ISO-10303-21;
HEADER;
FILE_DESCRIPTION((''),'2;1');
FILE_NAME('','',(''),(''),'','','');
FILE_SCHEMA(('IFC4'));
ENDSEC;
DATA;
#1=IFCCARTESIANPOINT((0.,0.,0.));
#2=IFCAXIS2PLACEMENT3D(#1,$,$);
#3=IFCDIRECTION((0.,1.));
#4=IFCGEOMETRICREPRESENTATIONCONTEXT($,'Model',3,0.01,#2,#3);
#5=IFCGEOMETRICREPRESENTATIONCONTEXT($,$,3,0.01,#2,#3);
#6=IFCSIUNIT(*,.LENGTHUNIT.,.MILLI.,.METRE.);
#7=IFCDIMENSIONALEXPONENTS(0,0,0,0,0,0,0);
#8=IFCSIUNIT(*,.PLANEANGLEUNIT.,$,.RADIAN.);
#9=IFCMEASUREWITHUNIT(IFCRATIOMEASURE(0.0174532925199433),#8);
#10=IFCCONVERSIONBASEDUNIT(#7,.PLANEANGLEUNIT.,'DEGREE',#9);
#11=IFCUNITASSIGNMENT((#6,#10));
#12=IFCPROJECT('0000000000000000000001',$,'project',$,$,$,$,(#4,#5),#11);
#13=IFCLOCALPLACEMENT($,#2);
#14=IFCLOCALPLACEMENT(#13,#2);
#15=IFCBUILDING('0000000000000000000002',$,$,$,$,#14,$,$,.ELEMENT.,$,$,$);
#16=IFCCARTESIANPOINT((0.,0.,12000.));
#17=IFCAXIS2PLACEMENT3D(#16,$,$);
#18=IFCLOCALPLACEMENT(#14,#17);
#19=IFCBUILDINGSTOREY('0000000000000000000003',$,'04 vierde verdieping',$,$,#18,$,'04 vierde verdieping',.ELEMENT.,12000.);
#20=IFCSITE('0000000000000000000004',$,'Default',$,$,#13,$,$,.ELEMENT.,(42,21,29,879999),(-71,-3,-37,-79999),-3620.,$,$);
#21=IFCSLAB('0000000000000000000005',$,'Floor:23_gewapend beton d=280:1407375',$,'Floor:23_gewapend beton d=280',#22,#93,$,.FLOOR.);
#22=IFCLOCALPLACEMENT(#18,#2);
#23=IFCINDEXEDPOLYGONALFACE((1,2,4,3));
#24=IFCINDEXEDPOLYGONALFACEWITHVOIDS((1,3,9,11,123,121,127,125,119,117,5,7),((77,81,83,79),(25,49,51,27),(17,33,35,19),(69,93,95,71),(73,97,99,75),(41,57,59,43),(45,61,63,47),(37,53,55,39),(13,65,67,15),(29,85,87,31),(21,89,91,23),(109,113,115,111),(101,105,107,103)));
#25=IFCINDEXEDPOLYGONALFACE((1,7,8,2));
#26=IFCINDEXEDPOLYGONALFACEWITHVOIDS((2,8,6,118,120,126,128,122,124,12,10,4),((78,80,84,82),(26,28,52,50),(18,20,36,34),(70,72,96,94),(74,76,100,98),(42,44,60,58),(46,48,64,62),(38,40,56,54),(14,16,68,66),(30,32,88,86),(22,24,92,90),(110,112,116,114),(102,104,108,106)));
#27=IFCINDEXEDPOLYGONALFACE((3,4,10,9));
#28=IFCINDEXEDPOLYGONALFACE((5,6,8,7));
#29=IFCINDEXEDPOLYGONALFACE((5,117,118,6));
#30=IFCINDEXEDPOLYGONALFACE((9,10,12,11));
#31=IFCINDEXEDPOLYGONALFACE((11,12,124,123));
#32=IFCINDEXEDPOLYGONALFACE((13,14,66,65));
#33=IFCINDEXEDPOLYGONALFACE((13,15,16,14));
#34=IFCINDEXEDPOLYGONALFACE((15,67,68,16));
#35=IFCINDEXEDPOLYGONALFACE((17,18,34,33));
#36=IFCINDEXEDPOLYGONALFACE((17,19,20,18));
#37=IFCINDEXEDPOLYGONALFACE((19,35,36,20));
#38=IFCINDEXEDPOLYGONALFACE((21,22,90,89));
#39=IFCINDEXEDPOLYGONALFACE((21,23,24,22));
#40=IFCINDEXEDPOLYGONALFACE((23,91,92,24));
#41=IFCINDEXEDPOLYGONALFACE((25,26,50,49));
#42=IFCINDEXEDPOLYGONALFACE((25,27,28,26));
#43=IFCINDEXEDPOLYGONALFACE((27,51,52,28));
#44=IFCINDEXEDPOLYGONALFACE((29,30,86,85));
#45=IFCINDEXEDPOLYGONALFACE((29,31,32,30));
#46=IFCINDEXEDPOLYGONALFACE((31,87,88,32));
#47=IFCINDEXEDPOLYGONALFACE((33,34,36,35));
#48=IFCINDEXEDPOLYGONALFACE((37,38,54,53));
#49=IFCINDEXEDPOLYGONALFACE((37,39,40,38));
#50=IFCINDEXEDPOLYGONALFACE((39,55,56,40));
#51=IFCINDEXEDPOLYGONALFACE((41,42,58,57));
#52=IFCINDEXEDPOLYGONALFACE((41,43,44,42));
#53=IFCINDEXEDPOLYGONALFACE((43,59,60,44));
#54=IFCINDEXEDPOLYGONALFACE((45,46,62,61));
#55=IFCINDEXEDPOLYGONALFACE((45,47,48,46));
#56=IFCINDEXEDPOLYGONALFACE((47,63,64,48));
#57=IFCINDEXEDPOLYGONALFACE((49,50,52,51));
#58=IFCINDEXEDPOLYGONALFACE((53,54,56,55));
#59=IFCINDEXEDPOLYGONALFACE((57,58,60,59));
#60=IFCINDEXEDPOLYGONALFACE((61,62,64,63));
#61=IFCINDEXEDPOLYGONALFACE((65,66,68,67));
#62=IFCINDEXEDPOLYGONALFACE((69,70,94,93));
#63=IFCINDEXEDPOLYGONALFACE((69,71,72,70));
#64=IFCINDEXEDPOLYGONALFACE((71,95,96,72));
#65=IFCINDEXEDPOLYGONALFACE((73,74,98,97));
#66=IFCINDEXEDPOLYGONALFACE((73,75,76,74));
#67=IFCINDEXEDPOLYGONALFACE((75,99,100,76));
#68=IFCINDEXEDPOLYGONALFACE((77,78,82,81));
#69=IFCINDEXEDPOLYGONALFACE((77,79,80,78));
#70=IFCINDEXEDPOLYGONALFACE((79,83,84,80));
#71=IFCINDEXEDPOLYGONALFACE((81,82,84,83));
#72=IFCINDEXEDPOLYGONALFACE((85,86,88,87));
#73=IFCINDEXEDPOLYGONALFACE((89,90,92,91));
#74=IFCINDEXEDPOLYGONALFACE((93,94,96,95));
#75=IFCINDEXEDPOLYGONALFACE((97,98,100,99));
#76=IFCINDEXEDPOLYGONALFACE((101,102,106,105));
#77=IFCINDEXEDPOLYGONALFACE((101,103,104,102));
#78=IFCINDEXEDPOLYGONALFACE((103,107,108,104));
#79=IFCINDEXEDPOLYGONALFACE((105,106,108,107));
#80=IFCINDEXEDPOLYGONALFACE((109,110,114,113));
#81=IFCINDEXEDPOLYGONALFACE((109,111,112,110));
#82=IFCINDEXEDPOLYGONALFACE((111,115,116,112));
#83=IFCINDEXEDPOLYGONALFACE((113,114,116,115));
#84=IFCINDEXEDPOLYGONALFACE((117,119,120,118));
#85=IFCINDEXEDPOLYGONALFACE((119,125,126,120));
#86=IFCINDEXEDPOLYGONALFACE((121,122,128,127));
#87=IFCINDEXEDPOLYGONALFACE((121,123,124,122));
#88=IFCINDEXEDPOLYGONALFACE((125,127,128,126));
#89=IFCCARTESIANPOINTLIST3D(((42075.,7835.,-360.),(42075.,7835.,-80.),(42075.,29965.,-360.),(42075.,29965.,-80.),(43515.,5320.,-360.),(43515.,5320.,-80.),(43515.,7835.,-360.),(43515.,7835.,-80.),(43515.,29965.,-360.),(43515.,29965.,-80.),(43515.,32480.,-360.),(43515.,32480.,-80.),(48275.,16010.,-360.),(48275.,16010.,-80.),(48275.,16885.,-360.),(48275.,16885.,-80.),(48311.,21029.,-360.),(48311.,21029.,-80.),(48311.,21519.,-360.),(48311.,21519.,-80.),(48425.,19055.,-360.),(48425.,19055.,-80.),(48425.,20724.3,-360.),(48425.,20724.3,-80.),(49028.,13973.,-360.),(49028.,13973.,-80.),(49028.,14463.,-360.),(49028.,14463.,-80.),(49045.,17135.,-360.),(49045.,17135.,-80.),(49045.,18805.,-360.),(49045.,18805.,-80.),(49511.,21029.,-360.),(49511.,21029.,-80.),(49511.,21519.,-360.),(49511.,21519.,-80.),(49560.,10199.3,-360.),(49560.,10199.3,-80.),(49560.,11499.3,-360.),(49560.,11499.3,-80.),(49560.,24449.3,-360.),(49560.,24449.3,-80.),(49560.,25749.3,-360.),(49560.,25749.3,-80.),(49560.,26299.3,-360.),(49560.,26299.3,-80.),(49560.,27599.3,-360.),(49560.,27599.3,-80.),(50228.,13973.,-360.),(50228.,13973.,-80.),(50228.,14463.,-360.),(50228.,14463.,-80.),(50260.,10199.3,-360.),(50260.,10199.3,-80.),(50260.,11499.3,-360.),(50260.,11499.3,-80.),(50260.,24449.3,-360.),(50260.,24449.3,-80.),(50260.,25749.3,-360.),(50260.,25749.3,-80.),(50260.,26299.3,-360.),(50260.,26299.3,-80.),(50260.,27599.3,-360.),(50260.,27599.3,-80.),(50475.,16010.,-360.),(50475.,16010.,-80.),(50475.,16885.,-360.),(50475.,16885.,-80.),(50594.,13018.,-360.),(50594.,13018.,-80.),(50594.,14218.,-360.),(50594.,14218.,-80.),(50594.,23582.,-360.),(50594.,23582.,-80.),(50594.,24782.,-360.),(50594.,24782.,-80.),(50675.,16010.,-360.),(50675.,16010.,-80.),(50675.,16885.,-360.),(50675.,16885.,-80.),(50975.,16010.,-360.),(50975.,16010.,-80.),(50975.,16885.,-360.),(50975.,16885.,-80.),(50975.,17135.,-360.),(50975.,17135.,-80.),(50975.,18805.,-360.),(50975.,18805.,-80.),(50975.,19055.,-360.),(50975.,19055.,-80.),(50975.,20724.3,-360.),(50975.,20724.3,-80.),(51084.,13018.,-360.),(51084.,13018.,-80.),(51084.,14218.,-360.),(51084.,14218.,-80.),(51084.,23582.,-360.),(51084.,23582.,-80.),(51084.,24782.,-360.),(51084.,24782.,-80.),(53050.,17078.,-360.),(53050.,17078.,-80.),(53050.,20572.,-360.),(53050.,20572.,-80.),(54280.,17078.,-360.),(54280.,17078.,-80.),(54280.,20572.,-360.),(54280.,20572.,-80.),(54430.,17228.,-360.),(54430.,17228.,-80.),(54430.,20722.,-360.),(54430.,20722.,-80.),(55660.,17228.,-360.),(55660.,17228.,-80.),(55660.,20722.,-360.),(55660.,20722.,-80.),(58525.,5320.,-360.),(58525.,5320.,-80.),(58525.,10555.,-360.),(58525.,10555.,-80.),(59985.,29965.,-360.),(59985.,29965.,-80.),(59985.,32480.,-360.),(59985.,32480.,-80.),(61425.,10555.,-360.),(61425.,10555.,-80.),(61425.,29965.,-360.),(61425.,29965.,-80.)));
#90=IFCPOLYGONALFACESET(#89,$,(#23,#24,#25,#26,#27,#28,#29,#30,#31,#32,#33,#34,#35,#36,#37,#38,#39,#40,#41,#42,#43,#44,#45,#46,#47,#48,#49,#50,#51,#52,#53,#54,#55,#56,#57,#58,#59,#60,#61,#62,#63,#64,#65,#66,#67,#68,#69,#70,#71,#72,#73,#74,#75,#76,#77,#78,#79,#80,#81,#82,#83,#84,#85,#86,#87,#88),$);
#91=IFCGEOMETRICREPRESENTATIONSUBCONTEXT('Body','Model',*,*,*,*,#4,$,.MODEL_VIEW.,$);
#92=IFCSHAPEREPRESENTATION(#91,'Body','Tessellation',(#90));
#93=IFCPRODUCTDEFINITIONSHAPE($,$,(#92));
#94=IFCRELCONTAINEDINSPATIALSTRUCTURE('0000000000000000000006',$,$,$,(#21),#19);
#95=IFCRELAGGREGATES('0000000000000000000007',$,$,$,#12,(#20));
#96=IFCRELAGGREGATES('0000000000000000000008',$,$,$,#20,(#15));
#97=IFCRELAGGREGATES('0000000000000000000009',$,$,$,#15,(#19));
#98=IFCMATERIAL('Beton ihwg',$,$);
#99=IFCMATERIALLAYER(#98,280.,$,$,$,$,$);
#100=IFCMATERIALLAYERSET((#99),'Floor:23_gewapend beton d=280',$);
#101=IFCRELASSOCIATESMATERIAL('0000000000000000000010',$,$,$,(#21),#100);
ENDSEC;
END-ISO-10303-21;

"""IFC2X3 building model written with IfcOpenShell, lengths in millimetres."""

from ifc_helpers import new_model, entity, si_unit, converted_unit, direction, frame, frame_2d, origin, place, context, subcontext, project, spatial, polyline, rectangle, outline, extrude, material, layer, layer_set, layer_usage, element, save


model = new_model("IFC2X3")

# Units and contexts
model_context = context("Model", 3, precision=0.01, world=origin(), true_north=direction((0.0, 1.0)))
context_of_model = context(None, 3, precision=0.01, world=origin(), true_north=direction((0.0, 1.0)))
body_context = subcontext(model_context, "Body", "Model", "MODEL_VIEW")
ifc_project = project(units=[si_unit("LENGTHUNIT", "METRE", prefix="MILLI"), converted_unit("PLANEANGLEUNIT", "DEGREE", entity("IfcRatioMeasure", 0.0174532925199433), si_unit("PLANEANGLEUNIT", "RADIAN"), dimensions=[0, 0, 0, 0, 0, 0, 0])], contexts=[model_context, context_of_model])

# Site, building, storey
site_placement = place(None, origin())
site = spatial("IfcSite", under=ifc_project, at=site_placement, Name="Default", CompositionType="ELEMENT", RefLatitude=(42, 21, 29, 879999), RefLongitude=(-71, -3, -37, -79999), RefElevation=-3620.0)
building_placement = place(site_placement, origin())
building = spatial("IfcBuilding", under=site, at=building_placement, CompositionType="ELEMENT")
storey_placement = place(building_placement, frame((0.0, 0.0, 12000.0)))
storey = spatial("IfcBuildingStorey", under=building, at=storey_placement, Name="04 vierde verdieping", LongName="04 vierde verdieping", CompositionType="ELEMENT", Elevation=12000.0)

# Slab, openings
ifc_material_1 = material(Name="Beton ihwg")
ifc_layer_1 = layer(ifc_material_1, 280.0)
ifc_layer_set_1 = layer_set([ifc_layer_1], Name="Floor:23_gewapend beton d=280")
ifc_layer_usage_1 = layer_usage(ifc_layer_set_1, "AXIS3", "POSITIVE", 0.0)
slab_1_placement = place(storey_placement, frame((42075.0, 5320.0, -360.0)))
slab_1 = element("IfcSlab", 1, at=slab_1_placement, inside=storey, material=ifc_layer_usage_1, Name="Floor:23_gewapend beton d=280:1407375", ObjectType="Floor:23_gewapend beton d=280", PredefinedType="FLOOR", context=body_context, shape_type="SweptSolid", body=[
    extrude(outline(polyline([(8235.0, 13580.0), (-8235.0, 13580.0), (-8235.0, 11065.0), (-9675.0, 11065.0), (-9675.0, -8345.0), (-6775.0, -8345.0), (-6775.0, -13580.0), (8235.0, -13580.0), (8235.0, -11065.0), (9675.0, -11065.0), (9675.0, 11065.0), (8235.0, 11065.0), (8235.0, 13580.0)])), frame((9675.0, 13580.0, 280.0), z_axis=(0.0, 0.0, -1.0), x_axis=(-1.0, 0.0, 0.0)), (0.0, 0.0, 1.0), 280.0),
])
opening_1_placement = place(storey_placement, frame((42075.0, 5320.0, -360.0)))
element("IfcOpeningElement", 2, at=opening_1_placement, cuts=slab_1, ObjectType="Opening", context=body_context, shape_type="SweptSolid", body=[
    extrude(rectangle(XDim=1669.3, YDim=2550.0, at=frame_2d((2050.0, 989.6), x_axis=(0.0, 1.0))), frame((9675.0, 13580.0, 280.0), z_axis=(0.0, 0.0, -1.0), x_axis=(-1.0, 0.0, 0.0)), (0.0, 0.0, 1.0), 280.0),
])
opening_2_placement = place(storey_placement, frame((42075.0, 5320.0, -360.0)))
element("IfcOpeningElement", 3, at=opening_2_placement, cuts=slab_1, ObjectType="Opening", context=body_context, shape_type="SweptSolid", body=[
    extrude(rectangle(XDim=1670.0, YDim=1930.0, at=frame_2d((1740.0, -930.0), x_axis=(0.0, 1.0))), frame((9675.0, 13580.0, 280.0), z_axis=(0.0, 0.0, -1.0), x_axis=(-1.0, 0.0, 0.0)), (0.0, 0.0, 1.0), 280.0),
])
opening_3_placement = place(storey_placement, frame((42075.0, 5320.0, -360.0)))
element("IfcOpeningElement", 4, at=opening_3_placement, cuts=slab_1, ObjectType="Opening", context=body_context, shape_type="SweptSolid", body=[
    extrude(rectangle(XDim=1300.0, YDim=700.0, at=frame_2d((1840.0, 8049.3), x_axis=(0.0, 1.0))), frame((9675.0, 13580.0, 280.0), z_axis=(0.0, 0.0, -1.0), x_axis=(-1.0, 0.0, 0.0)), (0.0, 0.0, 1.0), 280.0),
])
opening_4_placement = place(storey_placement, frame((42075.0, 5320.0, -360.0)))
element("IfcOpeningElement", 5, at=opening_4_placement, cuts=slab_1, ObjectType="Opening", context=body_context, shape_type="SweptSolid", body=[
    extrude(rectangle(XDim=1300.0, YDim=700.0, at=frame_2d((1840.0, 6199.3), x_axis=(0.0, 1.0))), frame((9675.0, 13580.0, 280.0), z_axis=(0.0, 0.0, -1.0), x_axis=(-1.0, 0.0, 0.0)), (0.0, 0.0, 1.0), 280.0),
])
opening_5_placement = place(storey_placement, frame((42075.0, 5320.0, -360.0)))
element("IfcOpeningElement", 6, at=opening_5_placement, cuts=slab_1, ObjectType="Opening", context=body_context, shape_type="SweptSolid", body=[
    extrude(rectangle(XDim=1300.0, YDim=700.0, at=frame_2d((1840.0, -8050.7), x_axis=(0.0, 1.0))), frame((9675.0, 13580.0, 280.0), z_axis=(0.0, 0.0, -1.0), x_axis=(-1.0, 0.0, 0.0)), (0.0, 0.0, 1.0), 280.0),
])
opening_6_placement = place(storey_placement, frame((42075.0, 5320.0, -360.0)))
element("IfcOpeningElement", 7, at=opening_6_placement, cuts=slab_1, ObjectType="Opening", context=body_context, shape_type="SweptSolid", body=[
    extrude(rectangle(XDim=875.0, YDim=2200.0, at=frame_2d((2375.0, -2452.5), x_axis=(0.0, 1.0))), frame((9675.0, 13580.0, 280.0), z_axis=(0.0, 0.0, -1.0), x_axis=(-1.0, 0.0, 0.0)), (0.0, 0.0, 1.0), 280.0),
])
opening_7_placement = place(storey_placement, frame((42075.0, 5320.0, -360.0)))
element("IfcOpeningElement", 8, at=opening_7_placement, cuts=slab_1, ObjectType="Opening", context=body_context, shape_type="SweptSolid", body=[
    extrude(rectangle(XDim=875.0, YDim=300.0, at=frame_2d((925.0, -2452.5), x_axis=(0.0, 1.0))), frame((9675.0, 13580.0, 280.0), z_axis=(0.0, 0.0, -1.0), x_axis=(-1.0, 0.0, 0.0)), (0.0, 0.0, 1.0), 280.0),
])
opening_8_placement = place(storey_placement, frame((42075.0, 5320.0, -360.0)))
element("IfcOpeningElement", 9, at=opening_8_placement, cuts=slab_1, ObjectType="Opening", context=body_context, shape_type="SweptSolid", body=[
    extrude(rectangle(XDim=3494.0, YDim=1230.0, at=frame_2d((-3295.0, 75.0), x_axis=(0.0, 1.0))), frame((9675.0, 13580.0, 280.0), z_axis=(0.0, 0.0, -1.0), x_axis=(-1.0, 0.0, 0.0)), (0.0, 0.0, 1.0), 280.0),
])
opening_9_placement = place(storey_placement, frame((42075.0, 5320.0, -360.0)))
element("IfcOpeningElement", 10, at=opening_9_placement, cuts=slab_1, ObjectType="Opening", context=body_context, shape_type="SweptSolid", body=[
    extrude(rectangle(XDim=3494.0, YDim=1230.0, at=frame_2d((-1915.0, -75.0), x_axis=(0.0, 1.0))), frame((9675.0, 13580.0, 280.0), z_axis=(0.0, 0.0, -1.0), x_axis=(-1.0, 0.0, 0.0)), (0.0, 0.0, 1.0), 280.0),
])
opening_10_placement = place(storey_placement, frame((42075.0, 5320.0, -360.0)))
element("IfcOpeningElement", 11, at=opening_10_placement, cuts=slab_1, ObjectType="Opening", context=body_context, shape_type="SweptSolid", body=[
    extrude(rectangle(XDim=490.0, YDim=1200.0, at=frame_2d((911.0, 5282.0), x_axis=(-1.0, 0.0))), frame((9675.0, 13580.0, 280.0), z_axis=(0.0, 0.0, -1.0), x_axis=(-1.0, 0.0, 0.0)), (0.0, 0.0, 1.0), 280.0),
])
opening_11_placement = place(storey_placement, frame((42075.0, 5320.0, -360.0)))
element("IfcOpeningElement", 12, at=opening_11_placement, cuts=slab_1, ObjectType="Opening", context=body_context, shape_type="SweptSolid", body=[
    extrude(rectangle(XDim=490.0, YDim=1200.0, at=frame_2d((2839.0, 2374.0), x_axis=(0.0, 1.0))), frame((9675.0, 13580.0, 280.0), z_axis=(0.0, 0.0, -1.0), x_axis=(-1.0, 0.0, 0.0)), (0.0, 0.0, 1.0), 280.0),
])
opening_12_placement = place(storey_placement, frame((42075.0, 5320.0, -360.0)))
element("IfcOpeningElement", 13, at=opening_12_placement, cuts=slab_1, ObjectType="Opening", context=body_context, shape_type="SweptSolid", body=[
    extrude(rectangle(XDim=490.0, YDim=1200.0, at=frame_2d((911.0, -5282.0), x_axis=(-1.0, 0.0))), frame((9675.0, 13580.0, 280.0), z_axis=(0.0, 0.0, -1.0), x_axis=(-1.0, 0.0, 0.0)), (0.0, 0.0, 1.0), 280.0),
])
opening_13_placement = place(storey_placement, frame((42075.0, 5320.0, -360.0)))
element("IfcOpeningElement", 14, at=opening_13_placement, cuts=slab_1, ObjectType="Opening", context=body_context, shape_type="SweptSolid", body=[
    extrude(rectangle(XDim=490.0, YDim=1200.0, at=frame_2d((2122.0, -4682.0), x_axis=(0.0, 1.0))), frame((9675.0, 13580.0, 280.0), z_axis=(0.0, 0.0, -1.0), x_axis=(-1.0, 0.0, 0.0)), (0.0, 0.0, 1.0), 280.0),
])

save(model, "model.ifc")
